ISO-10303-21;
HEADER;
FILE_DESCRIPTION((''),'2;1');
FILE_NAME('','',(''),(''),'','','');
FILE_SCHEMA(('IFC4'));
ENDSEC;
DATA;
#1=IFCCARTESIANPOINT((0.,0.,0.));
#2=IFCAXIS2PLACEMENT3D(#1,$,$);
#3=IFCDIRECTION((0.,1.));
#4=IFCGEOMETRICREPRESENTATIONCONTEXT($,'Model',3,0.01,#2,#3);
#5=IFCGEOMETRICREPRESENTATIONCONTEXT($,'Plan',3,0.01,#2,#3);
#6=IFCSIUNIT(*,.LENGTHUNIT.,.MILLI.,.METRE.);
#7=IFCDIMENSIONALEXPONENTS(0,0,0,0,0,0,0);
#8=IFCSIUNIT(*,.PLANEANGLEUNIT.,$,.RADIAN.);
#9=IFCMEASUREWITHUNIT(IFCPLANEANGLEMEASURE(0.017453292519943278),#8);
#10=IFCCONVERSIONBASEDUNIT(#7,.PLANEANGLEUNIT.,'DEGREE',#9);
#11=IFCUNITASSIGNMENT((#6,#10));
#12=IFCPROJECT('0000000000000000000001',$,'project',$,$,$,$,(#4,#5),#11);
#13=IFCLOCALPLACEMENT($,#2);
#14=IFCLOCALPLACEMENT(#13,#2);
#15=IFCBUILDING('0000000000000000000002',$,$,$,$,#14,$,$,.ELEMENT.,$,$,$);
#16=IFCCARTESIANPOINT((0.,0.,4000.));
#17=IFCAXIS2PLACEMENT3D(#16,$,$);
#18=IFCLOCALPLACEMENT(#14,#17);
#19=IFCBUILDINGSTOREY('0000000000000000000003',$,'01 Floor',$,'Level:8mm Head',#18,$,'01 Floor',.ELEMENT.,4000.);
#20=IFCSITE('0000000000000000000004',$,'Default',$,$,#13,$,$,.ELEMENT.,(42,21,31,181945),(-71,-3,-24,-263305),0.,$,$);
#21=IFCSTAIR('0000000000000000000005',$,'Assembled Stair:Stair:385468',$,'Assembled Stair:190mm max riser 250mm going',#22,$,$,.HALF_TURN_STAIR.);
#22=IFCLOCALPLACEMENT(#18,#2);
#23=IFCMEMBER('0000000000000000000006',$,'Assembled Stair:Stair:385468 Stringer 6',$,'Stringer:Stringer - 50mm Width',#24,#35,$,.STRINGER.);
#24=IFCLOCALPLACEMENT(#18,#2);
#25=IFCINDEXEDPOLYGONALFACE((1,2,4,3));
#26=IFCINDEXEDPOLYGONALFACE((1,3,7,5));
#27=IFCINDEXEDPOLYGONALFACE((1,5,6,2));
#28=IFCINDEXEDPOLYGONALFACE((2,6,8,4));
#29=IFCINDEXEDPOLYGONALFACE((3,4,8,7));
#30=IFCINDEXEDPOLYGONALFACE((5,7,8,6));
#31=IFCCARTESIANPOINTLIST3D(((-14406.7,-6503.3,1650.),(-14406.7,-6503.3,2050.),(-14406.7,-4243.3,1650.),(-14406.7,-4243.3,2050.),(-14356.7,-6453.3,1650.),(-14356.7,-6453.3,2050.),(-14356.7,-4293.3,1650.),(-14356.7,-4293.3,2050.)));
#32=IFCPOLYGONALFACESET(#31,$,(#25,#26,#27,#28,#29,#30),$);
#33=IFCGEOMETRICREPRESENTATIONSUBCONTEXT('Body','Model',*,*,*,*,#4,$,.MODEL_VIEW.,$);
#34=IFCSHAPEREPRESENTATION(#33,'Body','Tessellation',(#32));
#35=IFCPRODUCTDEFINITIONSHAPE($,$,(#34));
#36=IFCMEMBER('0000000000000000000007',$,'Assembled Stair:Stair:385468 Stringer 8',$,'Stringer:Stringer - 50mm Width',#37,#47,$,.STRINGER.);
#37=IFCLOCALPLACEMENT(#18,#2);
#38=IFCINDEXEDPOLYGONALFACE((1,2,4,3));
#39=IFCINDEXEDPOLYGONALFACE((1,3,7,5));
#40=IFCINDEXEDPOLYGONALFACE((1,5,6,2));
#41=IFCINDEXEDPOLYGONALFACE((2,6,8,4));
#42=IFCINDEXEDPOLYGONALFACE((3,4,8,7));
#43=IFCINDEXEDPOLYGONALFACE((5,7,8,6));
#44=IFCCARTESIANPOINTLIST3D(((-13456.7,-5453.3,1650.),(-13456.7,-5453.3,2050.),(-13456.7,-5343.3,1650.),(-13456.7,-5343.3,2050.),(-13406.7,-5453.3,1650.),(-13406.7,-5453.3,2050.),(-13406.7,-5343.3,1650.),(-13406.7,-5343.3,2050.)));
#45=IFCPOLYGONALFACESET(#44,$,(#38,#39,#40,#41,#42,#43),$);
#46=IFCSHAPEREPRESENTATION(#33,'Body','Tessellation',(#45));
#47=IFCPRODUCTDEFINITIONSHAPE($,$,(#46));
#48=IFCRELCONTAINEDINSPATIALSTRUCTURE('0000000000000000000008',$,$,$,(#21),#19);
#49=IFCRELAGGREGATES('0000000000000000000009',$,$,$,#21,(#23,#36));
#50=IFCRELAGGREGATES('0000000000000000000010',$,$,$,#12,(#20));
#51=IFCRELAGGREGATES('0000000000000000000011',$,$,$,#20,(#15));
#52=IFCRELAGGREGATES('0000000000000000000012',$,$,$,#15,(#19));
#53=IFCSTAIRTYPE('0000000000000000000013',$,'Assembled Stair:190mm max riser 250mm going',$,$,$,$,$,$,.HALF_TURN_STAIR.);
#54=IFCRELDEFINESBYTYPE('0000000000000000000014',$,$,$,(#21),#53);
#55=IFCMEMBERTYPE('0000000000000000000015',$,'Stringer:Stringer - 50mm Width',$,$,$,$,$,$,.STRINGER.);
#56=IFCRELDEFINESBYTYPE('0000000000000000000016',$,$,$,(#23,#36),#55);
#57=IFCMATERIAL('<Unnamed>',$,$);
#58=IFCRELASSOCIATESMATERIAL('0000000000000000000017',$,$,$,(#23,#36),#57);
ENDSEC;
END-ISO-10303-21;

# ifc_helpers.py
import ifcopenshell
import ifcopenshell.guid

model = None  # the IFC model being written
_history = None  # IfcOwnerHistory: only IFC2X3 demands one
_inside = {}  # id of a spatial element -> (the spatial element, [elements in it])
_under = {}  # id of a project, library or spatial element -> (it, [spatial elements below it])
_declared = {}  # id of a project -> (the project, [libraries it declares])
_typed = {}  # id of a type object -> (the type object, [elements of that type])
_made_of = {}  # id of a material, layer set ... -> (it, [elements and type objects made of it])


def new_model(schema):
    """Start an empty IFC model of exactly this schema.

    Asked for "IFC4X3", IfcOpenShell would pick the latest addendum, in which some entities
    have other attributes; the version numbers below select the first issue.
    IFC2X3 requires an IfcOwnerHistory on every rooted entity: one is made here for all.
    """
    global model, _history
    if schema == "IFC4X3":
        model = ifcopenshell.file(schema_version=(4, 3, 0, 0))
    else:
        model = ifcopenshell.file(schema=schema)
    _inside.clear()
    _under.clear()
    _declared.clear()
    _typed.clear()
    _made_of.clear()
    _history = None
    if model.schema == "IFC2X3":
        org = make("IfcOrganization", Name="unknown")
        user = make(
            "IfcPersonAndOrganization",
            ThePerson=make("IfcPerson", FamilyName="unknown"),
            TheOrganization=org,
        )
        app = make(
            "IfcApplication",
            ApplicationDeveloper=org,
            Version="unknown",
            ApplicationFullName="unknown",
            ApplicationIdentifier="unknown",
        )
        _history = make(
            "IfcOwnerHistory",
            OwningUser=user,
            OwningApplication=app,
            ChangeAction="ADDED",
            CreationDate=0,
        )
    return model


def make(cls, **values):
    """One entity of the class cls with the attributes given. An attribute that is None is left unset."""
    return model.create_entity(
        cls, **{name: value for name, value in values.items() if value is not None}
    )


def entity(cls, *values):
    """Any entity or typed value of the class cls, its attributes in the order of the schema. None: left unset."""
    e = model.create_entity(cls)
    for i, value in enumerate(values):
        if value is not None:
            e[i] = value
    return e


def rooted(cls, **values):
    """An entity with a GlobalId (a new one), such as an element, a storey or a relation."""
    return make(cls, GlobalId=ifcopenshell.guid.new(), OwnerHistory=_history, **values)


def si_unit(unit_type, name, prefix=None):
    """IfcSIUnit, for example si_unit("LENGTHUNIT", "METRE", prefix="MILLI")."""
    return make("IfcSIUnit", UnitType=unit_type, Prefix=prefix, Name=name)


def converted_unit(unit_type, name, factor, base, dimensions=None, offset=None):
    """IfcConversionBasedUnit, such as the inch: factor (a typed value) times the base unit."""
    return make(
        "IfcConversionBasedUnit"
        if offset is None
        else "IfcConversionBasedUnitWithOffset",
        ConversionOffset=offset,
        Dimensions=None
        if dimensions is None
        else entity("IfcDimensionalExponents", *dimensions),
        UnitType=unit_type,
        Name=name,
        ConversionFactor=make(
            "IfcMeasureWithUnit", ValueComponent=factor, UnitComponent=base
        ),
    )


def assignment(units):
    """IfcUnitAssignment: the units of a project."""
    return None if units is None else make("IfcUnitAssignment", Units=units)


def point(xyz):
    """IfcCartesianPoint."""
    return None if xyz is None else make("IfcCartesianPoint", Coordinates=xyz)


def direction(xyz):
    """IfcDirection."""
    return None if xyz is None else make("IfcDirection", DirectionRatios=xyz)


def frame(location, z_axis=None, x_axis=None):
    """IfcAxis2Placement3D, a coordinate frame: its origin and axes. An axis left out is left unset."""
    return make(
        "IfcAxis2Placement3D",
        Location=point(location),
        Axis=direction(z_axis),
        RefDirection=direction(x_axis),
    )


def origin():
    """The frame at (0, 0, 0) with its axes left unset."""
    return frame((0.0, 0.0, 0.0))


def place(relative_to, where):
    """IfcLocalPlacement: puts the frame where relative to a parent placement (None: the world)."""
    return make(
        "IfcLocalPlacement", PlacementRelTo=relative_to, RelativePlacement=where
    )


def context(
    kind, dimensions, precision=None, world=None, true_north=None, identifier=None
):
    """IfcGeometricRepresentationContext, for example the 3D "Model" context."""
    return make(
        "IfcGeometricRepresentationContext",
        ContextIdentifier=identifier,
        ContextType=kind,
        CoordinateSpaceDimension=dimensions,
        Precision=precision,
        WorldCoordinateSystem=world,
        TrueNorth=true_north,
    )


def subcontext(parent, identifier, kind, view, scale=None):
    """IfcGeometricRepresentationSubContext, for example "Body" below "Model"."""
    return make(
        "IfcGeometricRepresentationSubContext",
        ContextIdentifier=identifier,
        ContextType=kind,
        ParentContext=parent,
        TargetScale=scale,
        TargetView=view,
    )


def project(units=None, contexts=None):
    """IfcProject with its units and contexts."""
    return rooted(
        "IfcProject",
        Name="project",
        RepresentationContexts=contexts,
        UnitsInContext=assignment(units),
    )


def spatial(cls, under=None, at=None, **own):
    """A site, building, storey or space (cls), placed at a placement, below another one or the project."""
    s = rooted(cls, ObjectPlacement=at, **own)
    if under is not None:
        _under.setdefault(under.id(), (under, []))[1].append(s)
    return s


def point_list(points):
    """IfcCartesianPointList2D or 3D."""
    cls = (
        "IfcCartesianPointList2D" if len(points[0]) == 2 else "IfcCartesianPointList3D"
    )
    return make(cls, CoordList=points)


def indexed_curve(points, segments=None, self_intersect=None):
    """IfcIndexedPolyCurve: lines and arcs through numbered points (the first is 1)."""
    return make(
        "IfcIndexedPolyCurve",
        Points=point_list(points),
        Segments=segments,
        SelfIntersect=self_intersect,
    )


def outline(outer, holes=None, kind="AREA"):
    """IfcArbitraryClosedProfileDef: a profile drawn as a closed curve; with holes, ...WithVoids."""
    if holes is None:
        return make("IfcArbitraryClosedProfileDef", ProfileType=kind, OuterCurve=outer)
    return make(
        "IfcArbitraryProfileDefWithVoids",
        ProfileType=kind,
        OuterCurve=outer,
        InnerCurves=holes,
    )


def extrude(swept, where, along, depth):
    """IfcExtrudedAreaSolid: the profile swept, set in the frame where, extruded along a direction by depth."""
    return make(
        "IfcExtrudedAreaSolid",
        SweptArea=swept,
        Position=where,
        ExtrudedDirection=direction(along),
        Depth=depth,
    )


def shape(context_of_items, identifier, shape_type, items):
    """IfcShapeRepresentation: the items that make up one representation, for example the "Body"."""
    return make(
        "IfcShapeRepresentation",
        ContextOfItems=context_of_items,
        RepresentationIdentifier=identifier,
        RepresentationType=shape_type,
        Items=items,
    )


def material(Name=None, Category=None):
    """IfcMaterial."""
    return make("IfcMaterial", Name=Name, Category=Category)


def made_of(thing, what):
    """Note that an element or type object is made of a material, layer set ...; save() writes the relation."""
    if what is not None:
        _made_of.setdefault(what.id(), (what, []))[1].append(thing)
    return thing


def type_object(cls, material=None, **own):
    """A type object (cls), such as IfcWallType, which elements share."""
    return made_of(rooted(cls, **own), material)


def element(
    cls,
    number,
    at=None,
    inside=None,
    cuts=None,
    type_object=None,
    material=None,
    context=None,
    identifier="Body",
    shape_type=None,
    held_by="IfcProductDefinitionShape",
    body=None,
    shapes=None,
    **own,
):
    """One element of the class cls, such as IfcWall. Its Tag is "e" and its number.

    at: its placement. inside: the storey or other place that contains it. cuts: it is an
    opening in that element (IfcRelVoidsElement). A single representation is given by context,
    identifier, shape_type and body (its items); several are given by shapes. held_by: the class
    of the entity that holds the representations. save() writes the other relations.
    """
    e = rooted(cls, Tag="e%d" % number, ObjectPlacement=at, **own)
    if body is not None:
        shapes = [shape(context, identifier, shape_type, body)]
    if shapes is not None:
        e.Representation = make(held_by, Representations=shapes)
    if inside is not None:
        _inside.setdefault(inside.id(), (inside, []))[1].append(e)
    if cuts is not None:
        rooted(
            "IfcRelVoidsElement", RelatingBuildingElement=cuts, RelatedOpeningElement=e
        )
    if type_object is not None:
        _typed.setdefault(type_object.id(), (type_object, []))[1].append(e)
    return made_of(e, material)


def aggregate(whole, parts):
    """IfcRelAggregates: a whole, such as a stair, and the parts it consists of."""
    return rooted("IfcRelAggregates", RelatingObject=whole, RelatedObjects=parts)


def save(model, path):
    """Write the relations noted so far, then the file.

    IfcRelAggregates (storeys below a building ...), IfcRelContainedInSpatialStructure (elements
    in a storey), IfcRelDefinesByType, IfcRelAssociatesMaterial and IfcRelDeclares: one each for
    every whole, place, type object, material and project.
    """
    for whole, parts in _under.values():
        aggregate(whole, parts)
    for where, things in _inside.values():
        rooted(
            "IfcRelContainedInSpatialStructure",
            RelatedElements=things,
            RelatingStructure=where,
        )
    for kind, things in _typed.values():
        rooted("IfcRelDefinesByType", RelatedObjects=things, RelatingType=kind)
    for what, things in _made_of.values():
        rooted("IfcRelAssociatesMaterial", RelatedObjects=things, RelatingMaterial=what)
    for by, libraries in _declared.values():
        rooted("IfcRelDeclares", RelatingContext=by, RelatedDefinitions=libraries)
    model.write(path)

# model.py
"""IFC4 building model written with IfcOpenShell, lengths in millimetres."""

from ifc_helpers import new_model, entity, si_unit, converted_unit, direction, frame, origin, place, context, subcontext, project, spatial, indexed_curve, outline, extrude, material, type_object, element, aggregate, save


model = new_model("IFC4")

# Units and contexts
model_context = context("Model", 3, precision=0.01, world=origin(), true_north=direction((0.0, 1.0)))
plan_context = context("Plan", 3, precision=0.01, world=origin(), true_north=direction((0.0, 1.0)))
body_context = subcontext(model_context, "Body", "Model", "MODEL_VIEW")
ifc_project = project(units=[si_unit("LENGTHUNIT", "METRE", prefix="MILLI"), converted_unit("PLANEANGLEUNIT", "DEGREE", entity("IfcPlaneAngleMeasure", 0.017453292519943278), si_unit("PLANEANGLEUNIT", "RADIAN"), dimensions=[0, 0, 0, 0, 0, 0, 0])], contexts=[model_context, plan_context])

# Site, building, storey
site_placement = place(None, origin())
site = spatial("IfcSite", under=ifc_project, at=site_placement, Name="Default", CompositionType="ELEMENT", RefLatitude=(42, 21, 31, 181945), RefLongitude=(-71, -3, -24, -263305), RefElevation=0.0)
building_placement = place(site_placement, origin())
building = spatial("IfcBuilding", under=site, at=building_placement, CompositionType="ELEMENT")
storey_placement = place(building_placement, frame((0.0, 0.0, 4000.0)))
storey = spatial("IfcBuildingStorey", under=building, at=storey_placement, Name="01 Floor", ObjectType="Level:8mm Head", LongName="01 Floor", CompositionType="ELEMENT", Elevation=4000.0)

# Stair, members
stair_type = type_object("IfcStairType", Name="Assembled Stair:190mm max riser 250mm going", PredefinedType="HALF_TURN_STAIR")
stair_placement = place(storey_placement, origin())
stair = element("IfcStair", 1, at=stair_placement, inside=storey, type_object=stair_type, Name="Assembled Stair:Stair:385468", ObjectType="Assembled Stair:190mm max riser 250mm going", PredefinedType="HALF_TURN_STAIR")
ifc_material_1 = material(Name="<Unnamed>")
member_type = type_object("IfcMemberType", Name="Stringer:Stringer - 50mm Width", PredefinedType="STRINGER")
member_1_placement = place(stair_placement, origin())
member_1 = element("IfcMember", 2, at=member_1_placement, type_object=member_type, material=ifc_material_1, Name="Assembled Stair:Stair:385468 Stringer 6", ObjectType="Stringer:Stringer - 50mm Width", PredefinedType="STRINGER", context=body_context, shape_type="SweptSolid", body=[
    extrude(outline(indexed_curve([(-1130.0, -25.0), (1130.0, -25.0), (1080.0, 25.0), (-1080.0, 25.0), (-1130.0, -25.0)], self_intersect=False)), frame((-14381.7, -5373.3, 1650.0), z_axis=(0.0, 0.0, 1.0), x_axis=(0.0, -1.0, 0.0)), (0.0, 0.0, 1.0), 400.0),
])
member_2_placement = place(stair_placement, origin())
member_2 = element("IfcMember", 3, at=member_2_placement, type_object=member_type, material=ifc_material_1, Name="Assembled Stair:Stair:385468 Stringer 8", ObjectType="Stringer:Stringer - 50mm Width", PredefinedType="STRINGER", context=body_context, shape_type="SweptSolid", body=[
    extrude(outline(indexed_curve([(-55.0, -25.0), (55.0, -25.0), (55.0, 25.0), (-55.0, 25.0), (-55.0, -25.0)], self_intersect=False)), frame((-13431.7, -5398.3, 1650.0), z_axis=(0.0, 0.0, 1.0), x_axis=(0.0, 1.0, 0.0)), (0.0, 0.0, 1.0), 400.0),
])

aggregate(stair, [member_1, member_2])

save(model, "model.ifc")
